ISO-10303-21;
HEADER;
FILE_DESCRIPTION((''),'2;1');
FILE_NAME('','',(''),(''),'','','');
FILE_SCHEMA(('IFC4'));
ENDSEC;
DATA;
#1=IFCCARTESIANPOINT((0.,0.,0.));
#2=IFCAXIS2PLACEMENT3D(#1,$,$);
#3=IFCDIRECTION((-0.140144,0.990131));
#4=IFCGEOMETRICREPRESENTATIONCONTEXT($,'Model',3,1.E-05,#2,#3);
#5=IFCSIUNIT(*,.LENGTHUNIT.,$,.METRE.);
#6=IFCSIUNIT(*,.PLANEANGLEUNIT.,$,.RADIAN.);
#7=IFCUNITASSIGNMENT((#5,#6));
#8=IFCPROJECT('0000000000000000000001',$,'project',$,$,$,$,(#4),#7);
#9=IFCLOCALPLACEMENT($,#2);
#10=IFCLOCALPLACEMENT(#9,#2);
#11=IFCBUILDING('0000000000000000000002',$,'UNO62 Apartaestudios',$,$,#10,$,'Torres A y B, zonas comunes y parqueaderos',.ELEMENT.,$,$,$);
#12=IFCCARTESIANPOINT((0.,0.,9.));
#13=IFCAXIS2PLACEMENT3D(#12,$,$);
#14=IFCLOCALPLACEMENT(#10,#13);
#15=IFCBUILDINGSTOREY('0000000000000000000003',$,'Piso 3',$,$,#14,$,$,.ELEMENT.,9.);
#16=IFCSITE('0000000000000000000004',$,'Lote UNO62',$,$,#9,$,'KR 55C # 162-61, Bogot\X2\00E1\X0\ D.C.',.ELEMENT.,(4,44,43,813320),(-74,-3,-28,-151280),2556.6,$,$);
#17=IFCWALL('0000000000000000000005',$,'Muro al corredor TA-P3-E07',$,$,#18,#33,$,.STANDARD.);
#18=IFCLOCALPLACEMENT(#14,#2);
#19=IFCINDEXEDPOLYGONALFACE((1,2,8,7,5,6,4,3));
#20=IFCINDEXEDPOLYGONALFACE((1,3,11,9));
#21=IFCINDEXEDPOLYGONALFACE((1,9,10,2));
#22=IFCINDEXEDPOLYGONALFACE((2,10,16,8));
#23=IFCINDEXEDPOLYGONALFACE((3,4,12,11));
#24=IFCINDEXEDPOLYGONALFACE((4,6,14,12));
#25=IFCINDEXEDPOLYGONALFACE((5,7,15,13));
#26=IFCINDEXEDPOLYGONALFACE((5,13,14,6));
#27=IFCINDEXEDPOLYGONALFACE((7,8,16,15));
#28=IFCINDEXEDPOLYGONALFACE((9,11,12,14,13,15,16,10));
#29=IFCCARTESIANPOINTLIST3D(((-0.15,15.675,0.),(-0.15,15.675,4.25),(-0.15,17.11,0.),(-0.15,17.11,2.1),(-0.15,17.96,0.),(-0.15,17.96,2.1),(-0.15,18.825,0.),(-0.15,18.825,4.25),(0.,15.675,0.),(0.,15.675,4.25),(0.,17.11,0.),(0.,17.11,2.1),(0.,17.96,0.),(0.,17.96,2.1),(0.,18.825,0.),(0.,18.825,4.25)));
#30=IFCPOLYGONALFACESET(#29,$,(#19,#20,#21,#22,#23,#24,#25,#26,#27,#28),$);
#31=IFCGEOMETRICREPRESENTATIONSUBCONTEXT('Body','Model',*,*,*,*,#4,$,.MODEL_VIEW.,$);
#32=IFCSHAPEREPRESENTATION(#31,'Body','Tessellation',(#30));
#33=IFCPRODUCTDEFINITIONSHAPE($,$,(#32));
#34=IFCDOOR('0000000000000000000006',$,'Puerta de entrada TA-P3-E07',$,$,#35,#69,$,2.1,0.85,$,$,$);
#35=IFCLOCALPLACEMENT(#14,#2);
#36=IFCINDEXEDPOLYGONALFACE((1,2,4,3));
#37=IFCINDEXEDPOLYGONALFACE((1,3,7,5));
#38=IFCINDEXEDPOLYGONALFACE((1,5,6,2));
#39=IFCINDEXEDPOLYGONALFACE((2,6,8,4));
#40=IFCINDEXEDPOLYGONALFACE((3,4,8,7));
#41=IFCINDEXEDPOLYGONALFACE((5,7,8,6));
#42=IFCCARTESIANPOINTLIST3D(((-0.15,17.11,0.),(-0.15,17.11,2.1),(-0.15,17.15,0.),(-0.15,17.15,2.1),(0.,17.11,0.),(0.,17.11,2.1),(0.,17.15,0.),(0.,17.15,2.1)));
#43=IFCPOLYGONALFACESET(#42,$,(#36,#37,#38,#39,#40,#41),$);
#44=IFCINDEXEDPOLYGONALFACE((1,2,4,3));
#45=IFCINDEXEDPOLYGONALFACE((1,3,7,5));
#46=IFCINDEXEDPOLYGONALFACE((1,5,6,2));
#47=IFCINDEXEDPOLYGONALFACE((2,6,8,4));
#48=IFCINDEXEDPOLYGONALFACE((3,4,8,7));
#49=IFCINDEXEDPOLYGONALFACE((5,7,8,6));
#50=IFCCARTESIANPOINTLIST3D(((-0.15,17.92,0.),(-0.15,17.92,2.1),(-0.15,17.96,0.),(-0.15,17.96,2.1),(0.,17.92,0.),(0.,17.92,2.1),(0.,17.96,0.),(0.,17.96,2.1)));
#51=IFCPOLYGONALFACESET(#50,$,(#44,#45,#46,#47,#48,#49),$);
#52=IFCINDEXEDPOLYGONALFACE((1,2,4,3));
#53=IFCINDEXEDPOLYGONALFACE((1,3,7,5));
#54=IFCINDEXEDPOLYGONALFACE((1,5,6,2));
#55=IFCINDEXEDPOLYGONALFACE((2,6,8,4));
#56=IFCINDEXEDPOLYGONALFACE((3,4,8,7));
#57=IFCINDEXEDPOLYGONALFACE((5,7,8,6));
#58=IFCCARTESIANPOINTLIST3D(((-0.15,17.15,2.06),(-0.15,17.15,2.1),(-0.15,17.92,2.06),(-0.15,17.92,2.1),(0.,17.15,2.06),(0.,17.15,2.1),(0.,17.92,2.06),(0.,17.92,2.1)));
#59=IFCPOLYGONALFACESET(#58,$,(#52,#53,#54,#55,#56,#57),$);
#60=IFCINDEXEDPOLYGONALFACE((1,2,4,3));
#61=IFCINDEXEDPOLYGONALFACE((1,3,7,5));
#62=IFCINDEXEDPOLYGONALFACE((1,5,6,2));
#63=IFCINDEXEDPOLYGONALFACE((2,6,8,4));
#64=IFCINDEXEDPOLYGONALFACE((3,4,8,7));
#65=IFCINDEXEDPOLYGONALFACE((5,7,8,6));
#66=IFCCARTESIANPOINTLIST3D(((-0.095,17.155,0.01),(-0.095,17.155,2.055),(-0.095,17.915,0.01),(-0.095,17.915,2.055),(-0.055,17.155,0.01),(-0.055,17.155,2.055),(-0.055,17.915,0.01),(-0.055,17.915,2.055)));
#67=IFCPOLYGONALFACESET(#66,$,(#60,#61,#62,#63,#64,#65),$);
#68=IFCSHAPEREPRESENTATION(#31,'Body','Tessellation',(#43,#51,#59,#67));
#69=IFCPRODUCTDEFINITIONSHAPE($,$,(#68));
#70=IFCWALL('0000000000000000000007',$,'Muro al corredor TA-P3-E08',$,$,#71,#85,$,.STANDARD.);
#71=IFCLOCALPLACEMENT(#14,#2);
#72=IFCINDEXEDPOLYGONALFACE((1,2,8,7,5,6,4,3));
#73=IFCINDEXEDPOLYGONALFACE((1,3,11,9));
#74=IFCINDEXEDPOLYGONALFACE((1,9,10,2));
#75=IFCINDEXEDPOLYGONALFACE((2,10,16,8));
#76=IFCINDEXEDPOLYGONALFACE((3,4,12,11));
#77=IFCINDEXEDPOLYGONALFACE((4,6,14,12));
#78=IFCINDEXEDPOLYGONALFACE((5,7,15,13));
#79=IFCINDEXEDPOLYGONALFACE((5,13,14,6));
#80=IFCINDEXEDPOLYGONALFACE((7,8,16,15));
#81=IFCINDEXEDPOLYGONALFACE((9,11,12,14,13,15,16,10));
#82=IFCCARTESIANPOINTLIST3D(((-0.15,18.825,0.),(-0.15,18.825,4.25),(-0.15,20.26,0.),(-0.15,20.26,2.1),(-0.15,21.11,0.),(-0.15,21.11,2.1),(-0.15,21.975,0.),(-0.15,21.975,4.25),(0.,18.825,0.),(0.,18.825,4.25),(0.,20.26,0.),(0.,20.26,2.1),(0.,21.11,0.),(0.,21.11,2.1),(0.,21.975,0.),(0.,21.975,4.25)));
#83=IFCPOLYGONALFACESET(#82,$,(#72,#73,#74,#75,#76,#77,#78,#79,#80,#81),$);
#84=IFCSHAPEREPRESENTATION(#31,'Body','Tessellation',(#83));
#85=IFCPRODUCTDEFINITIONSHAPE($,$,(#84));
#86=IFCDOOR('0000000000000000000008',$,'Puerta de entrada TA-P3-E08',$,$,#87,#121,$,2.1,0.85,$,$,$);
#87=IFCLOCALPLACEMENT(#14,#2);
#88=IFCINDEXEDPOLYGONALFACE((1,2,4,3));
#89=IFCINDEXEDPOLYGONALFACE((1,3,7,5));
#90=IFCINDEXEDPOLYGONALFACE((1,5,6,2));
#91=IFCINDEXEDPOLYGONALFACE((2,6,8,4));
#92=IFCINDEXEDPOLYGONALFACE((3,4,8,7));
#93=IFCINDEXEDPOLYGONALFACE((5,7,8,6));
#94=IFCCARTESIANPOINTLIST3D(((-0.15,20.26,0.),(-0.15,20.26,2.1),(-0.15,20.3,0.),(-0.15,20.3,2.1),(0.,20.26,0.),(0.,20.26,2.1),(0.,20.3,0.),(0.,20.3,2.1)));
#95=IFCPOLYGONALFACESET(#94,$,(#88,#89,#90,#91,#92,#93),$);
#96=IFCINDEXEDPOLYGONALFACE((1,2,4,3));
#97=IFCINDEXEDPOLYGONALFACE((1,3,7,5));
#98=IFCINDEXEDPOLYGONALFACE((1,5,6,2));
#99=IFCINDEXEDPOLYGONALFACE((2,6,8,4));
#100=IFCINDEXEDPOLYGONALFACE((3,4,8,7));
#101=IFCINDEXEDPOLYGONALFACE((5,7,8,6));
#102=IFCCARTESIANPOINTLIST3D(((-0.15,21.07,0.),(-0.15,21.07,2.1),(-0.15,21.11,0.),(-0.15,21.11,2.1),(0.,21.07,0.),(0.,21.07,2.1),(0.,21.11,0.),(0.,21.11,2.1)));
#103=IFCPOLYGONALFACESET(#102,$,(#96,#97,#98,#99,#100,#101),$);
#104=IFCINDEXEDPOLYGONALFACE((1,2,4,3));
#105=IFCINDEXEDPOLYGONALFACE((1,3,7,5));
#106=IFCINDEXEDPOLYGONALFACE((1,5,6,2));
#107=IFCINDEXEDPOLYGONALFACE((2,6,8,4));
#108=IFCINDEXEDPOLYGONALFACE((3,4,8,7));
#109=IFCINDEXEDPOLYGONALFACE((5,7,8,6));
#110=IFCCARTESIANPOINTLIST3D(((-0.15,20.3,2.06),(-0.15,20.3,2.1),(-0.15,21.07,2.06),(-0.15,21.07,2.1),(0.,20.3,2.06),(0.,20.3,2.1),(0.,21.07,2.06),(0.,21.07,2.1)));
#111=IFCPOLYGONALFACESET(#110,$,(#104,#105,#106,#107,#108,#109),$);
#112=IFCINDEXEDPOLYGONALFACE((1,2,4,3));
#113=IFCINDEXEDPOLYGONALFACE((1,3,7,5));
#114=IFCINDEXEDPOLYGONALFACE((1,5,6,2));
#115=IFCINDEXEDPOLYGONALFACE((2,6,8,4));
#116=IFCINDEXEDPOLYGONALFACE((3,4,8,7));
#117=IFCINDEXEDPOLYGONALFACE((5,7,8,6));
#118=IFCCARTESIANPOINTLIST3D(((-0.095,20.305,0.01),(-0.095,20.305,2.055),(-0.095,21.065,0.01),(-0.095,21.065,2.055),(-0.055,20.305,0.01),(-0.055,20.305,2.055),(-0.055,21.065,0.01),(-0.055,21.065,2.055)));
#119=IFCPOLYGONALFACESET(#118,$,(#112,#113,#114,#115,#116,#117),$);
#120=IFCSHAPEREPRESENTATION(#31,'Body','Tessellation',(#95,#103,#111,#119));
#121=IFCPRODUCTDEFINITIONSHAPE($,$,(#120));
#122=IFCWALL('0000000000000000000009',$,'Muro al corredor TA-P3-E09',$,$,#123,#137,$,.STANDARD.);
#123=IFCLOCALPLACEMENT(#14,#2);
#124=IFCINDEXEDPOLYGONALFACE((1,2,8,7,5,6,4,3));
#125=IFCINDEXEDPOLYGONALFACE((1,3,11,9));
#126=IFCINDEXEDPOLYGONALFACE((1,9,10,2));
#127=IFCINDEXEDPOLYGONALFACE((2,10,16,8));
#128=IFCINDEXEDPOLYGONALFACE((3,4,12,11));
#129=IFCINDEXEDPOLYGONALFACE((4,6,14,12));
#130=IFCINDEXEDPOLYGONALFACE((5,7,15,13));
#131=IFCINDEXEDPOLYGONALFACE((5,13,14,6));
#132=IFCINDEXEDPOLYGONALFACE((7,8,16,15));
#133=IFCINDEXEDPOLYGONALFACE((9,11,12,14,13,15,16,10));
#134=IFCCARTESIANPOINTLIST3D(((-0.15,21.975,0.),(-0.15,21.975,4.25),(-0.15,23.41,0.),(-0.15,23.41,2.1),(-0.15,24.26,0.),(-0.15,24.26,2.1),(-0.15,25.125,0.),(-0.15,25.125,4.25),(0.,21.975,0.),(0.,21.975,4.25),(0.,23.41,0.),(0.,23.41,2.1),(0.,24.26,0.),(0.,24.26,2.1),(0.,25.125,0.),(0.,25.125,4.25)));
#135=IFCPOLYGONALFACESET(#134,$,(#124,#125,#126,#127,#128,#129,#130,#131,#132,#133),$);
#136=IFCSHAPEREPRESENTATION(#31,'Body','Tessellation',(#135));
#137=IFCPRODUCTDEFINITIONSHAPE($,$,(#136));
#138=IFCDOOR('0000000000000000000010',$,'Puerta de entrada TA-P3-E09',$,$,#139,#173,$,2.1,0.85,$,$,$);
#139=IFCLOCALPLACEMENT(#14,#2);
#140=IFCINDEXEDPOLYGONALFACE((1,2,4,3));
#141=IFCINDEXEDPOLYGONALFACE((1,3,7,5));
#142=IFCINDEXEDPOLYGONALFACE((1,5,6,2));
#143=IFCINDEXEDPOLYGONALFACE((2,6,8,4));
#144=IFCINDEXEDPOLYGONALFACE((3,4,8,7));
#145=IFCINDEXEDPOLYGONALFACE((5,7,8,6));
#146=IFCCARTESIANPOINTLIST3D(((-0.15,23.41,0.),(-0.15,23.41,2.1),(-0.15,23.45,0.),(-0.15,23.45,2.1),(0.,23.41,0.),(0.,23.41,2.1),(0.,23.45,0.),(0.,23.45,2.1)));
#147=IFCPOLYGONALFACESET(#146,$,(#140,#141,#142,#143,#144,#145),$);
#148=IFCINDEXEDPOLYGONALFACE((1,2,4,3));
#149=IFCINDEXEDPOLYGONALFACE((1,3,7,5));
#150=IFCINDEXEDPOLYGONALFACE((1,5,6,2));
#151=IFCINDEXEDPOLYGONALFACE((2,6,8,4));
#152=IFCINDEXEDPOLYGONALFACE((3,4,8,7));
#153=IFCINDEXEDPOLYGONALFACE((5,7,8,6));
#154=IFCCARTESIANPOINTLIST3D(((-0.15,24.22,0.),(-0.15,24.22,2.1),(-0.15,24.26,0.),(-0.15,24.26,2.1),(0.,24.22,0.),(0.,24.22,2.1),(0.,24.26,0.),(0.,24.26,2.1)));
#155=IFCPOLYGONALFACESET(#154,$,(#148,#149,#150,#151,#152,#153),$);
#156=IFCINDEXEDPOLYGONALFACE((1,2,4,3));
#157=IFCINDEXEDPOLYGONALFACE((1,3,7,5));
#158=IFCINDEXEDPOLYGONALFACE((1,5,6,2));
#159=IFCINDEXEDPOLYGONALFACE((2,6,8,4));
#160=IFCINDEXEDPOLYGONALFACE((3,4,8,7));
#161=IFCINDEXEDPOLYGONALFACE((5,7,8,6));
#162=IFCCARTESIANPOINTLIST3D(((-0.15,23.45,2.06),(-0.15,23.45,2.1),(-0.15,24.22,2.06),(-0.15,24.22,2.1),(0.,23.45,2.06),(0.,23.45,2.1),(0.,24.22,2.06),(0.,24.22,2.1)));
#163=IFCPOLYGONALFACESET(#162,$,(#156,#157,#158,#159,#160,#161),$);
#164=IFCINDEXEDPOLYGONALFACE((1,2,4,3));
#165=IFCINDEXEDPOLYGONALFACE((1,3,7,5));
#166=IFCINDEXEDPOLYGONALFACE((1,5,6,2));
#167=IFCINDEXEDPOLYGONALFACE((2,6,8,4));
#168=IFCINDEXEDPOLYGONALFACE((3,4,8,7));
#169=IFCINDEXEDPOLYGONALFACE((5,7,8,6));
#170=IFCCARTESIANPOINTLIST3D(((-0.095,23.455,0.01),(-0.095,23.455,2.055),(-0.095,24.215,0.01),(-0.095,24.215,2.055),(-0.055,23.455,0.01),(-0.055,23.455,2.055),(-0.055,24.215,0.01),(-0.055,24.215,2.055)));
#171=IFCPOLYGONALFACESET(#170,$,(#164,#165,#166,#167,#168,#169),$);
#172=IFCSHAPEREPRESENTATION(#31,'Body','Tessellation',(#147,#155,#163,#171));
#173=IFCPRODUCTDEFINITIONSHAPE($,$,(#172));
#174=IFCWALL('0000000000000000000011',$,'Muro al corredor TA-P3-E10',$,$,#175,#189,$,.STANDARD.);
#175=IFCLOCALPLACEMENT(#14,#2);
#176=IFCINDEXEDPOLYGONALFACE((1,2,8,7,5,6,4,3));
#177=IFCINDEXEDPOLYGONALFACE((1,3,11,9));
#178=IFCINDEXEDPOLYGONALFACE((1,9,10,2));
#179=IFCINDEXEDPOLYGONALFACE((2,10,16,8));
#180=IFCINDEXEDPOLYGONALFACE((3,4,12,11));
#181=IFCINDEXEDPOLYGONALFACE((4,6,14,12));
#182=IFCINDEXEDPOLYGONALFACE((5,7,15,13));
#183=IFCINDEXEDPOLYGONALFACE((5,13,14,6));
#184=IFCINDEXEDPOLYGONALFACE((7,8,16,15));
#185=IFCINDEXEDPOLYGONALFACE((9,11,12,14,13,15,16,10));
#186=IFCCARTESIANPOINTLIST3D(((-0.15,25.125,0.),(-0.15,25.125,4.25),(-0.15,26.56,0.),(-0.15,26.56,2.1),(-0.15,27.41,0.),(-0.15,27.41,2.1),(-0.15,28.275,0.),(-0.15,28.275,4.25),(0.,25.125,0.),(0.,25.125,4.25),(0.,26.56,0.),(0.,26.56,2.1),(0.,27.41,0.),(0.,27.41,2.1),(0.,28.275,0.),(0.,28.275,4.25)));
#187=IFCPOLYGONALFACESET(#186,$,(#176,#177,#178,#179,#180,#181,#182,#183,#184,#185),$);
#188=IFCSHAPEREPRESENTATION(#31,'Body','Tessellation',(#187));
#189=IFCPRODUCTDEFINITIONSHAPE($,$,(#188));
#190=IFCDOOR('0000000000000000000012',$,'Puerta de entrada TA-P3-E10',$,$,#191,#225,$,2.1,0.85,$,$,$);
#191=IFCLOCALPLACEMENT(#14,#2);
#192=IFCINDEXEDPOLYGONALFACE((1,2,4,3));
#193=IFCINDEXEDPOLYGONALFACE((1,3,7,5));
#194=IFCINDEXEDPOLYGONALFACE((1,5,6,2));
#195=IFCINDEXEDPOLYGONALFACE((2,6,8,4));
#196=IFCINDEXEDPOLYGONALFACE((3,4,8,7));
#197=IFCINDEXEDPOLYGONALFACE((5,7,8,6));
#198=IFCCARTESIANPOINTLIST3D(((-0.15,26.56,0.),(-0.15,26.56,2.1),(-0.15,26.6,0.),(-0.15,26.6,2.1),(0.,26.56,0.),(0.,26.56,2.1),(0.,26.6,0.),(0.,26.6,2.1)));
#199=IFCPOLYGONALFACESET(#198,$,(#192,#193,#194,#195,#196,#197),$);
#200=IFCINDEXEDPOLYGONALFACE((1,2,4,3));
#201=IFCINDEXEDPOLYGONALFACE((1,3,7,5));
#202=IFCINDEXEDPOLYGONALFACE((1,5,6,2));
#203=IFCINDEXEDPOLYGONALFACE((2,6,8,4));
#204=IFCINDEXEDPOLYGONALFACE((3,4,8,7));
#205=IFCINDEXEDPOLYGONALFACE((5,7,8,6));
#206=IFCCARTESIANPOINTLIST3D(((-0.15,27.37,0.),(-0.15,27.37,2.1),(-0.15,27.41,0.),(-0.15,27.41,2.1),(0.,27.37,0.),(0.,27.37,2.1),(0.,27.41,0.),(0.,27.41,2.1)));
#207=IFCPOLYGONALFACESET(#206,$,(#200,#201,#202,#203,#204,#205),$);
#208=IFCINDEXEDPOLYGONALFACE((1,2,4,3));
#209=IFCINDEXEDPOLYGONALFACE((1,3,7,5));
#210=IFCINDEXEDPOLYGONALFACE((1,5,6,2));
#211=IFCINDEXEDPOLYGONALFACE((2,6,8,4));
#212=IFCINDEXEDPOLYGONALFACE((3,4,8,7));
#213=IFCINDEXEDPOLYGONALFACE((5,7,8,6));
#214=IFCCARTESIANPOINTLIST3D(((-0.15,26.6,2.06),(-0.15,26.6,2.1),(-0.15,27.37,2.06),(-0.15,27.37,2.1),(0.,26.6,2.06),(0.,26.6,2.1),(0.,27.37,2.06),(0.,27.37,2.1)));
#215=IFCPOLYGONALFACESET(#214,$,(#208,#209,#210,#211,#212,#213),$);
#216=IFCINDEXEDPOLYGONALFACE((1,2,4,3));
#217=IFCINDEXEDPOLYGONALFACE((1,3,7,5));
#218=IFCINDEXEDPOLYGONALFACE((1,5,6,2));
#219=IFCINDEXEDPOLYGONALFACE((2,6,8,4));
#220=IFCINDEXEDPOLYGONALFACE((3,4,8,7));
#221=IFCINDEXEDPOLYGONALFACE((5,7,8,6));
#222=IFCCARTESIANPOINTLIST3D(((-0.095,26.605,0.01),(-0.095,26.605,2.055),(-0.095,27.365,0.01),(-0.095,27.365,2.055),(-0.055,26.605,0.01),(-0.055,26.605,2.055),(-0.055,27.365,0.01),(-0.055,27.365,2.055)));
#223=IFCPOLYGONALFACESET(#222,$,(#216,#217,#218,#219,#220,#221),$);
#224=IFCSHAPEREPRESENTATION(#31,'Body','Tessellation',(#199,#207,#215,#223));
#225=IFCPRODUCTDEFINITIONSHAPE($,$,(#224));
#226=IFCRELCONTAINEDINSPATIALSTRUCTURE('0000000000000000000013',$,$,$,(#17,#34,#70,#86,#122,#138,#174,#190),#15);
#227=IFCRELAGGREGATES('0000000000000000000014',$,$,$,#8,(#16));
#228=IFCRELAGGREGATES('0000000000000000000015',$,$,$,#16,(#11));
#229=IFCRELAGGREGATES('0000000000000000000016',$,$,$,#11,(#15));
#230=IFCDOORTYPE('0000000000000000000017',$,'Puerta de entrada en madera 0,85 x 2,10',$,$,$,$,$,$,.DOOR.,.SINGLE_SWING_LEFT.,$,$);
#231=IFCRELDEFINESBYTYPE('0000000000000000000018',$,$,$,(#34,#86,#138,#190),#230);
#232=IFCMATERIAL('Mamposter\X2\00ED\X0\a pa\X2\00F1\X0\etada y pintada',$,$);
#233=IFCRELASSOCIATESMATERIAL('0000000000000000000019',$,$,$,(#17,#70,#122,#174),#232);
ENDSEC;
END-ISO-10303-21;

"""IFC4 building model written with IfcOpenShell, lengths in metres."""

from ifc_helpers import new_model, si_unit, direction, frame, frame_2d, origin, place, context, subcontext, project, spatial, rectangle, extrude, source, transform, mapped, material, type_object, type_shapes, element, fill, save


model = new_model("IFC4")

# Units and contexts
model_context = context("Model", 3, precision=1e-05, world=origin(), true_north=direction((-0.140144, 0.990131)))
body_context = subcontext(model_context, "Body", "Model", "MODEL_VIEW")
ifc_project = project(units=[si_unit("LENGTHUNIT", "METRE"), si_unit("PLANEANGLEUNIT", "RADIAN")], contexts=[model_context])

# Site, building, storey
site_placement = place(None, origin())
site = spatial("IfcSite", under=ifc_project, at=site_placement, Name="Lote UNO62", LongName="KR 55C # 162-61, Bogotá D.C.", CompositionType="ELEMENT", RefLatitude=(4, 44, 43, 813320), RefLongitude=(-74, -3, -28, -151280), RefElevation=2556.6)
building_placement = place(site_placement, origin())
building = spatial("IfcBuilding", under=site, at=building_placement, Name="UNO62 Apartaestudios", LongName="Torres A y B, zonas comunes y parqueaderos", CompositionType="ELEMENT")
storey_placement = place(building_placement, frame((0.0, 0.0, 9.0)))
storey = spatial("IfcBuildingStorey", under=building, at=storey_placement, Name="Piso 3", CompositionType="ELEMENT", Elevation=9.0)

# Walls, openings, doors
ifc_material = material(Name="Mampostería pañetada y pintada")
wall_1_placement = place(storey_placement, origin())
wall_1 = element("IfcWall", 1, at=wall_1_placement, inside=storey, material=ifc_material, Name="Muro al corredor TA-P3-E07", PredefinedType="STANDARD", context=body_context, shape_type="SweptSolid", body=[
    extrude(rectangle(XDim=0.15, YDim=3.15, at=frame_2d((-0.075, 17.25))), origin(), (0.0, 0.0, 1.0), 4.25),
])
opening_1_placement = place(wall_1_placement, origin())
opening_1 = element("IfcOpeningElement", 2, at=opening_1_placement, cuts=wall_1, PredefinedType="OPENING", context=body_context, shape_type="SweptSolid", body=[
    extrude(rectangle(XDim=0.25, YDim=0.85, at=frame_2d((-0.075, 17.535))), origin(), (0.0, 0.0, 1.0), 2.1),
])
door_type = type_object("IfcDoorType", Name="Puerta de entrada en madera 0,85 x 2,10", OperationType="SINGLE_SWING_LEFT", PredefinedType="DOOR")
shared_shape = source(origin(), body_context, "Body", "SweptSolid", [
    extrude(rectangle(XDim=0.15, YDim=0.04, at=frame_2d((-0.075, 1.38))), origin(), (0.0, 0.0, 1.0), 2.1),
    extrude(rectangle(XDim=0.15, YDim=0.04, at=frame_2d((-0.075, 2.19))), origin(), (0.0, 0.0, 1.0), 2.1),
    extrude(rectangle(XDim=0.15, YDim=0.77, at=frame_2d((-0.075, 1.785))), frame((0.0, 0.0, 2.06)), (0.0, 0.0, 1.0), 0.04),
    extrude(rectangle(XDim=0.04, YDim=0.76, at=frame_2d((-0.075, 1.785))), frame((0.0, 0.0, 0.01)), (0.0, 0.0, 1.0), 2.045),
])
type_shapes(door_type, [shared_shape])
placement_1 = place(storey_placement, frame((0.0, 15.75, 0.0)))
door_1_placement = place(placement_1, origin())
door_1 = element("IfcDoor", 3, at=door_1_placement, inside=storey, type_object=door_type, Name="Puerta de entrada TA-P3-E07", OverallHeight=2.1, OverallWidth=0.85, context=body_context, shape_type="MappedRepresentation", body=[
    mapped(shared_shape, transform((0.0, 0.0, 0.0))),
])
fill(opening_1, door_1)
wall_2_placement = place(storey_placement, origin())
wall_2 = element("IfcWall", 4, at=wall_2_placement, inside=storey, material=ifc_material, Name="Muro al corredor TA-P3-E08", PredefinedType="STANDARD", context=body_context, shape_type="SweptSolid", body=[
    extrude(rectangle(XDim=0.15, YDim=3.15, at=frame_2d((-0.075, 20.4))), origin(), (0.0, 0.0, 1.0), 4.25),
])
opening_2_placement = place(wall_2_placement, origin())
opening_2 = element("IfcOpeningElement", 5, at=opening_2_placement, cuts=wall_2, PredefinedType="OPENING", context=body_context, shape_type="SweptSolid", body=[
    extrude(rectangle(XDim=0.25, YDim=0.85, at=frame_2d((-0.075, 20.685))), origin(), (0.0, 0.0, 1.0), 2.1),
])
placement_2 = place(storey_placement, frame((0.0, 18.9, 0.0)))
door_2_placement = place(placement_2, origin())
door_2 = element("IfcDoor", 6, at=door_2_placement, inside=storey, type_object=door_type, Name="Puerta de entrada TA-P3-E08", OverallHeight=2.1, OverallWidth=0.85, context=body_context, shape_type="MappedRepresentation", body=[
    mapped(shared_shape, transform((0.0, 0.0, 0.0))),
])
fill(opening_2, door_2)
wall_3_placement = place(storey_placement, origin())
wall_3 = element("IfcWall", 7, at=wall_3_placement, inside=storey, material=ifc_material, Name="Muro al corredor TA-P3-E09", PredefinedType="STANDARD", context=body_context, shape_type="SweptSolid", body=[
    extrude(rectangle(XDim=0.15, YDim=3.15, at=frame_2d((-0.075, 23.55))), origin(), (0.0, 0.0, 1.0), 4.25),
])
opening_3_placement = place(wall_3_placement, origin())
opening_3 = element("IfcOpeningElement", 8, at=opening_3_placement, cuts=wall_3, PredefinedType="OPENING", context=body_context, shape_type="SweptSolid", body=[
    extrude(rectangle(XDim=0.25, YDim=0.85, at=frame_2d((-0.075, 23.835))), origin(), (0.0, 0.0, 1.0), 2.1),
])
placement_3 = place(storey_placement, frame((0.0, 22.05, 0.0)))
door_3_placement = place(placement_3, origin())
door_3 = element("IfcDoor", 9, at=door_3_placement, inside=storey, type_object=door_type, Name="Puerta de entrada TA-P3-E09", OverallHeight=2.1, OverallWidth=0.85, context=body_context, shape_type="MappedRepresentation", body=[
    mapped(shared_shape, transform((0.0, 0.0, 0.0))),
])
fill(opening_3, door_3)
wall_4_placement = place(storey_placement, origin())
wall_4 = element("IfcWall", 10, at=wall_4_placement, inside=storey, material=ifc_material, Name="Muro al corredor TA-P3-E10", PredefinedType="STANDARD", context=body_context, shape_type="SweptSolid", body=[
    extrude(rectangle(XDim=0.15, YDim=3.15, at=frame_2d((-0.075, 26.7))), origin(), (0.0, 0.0, 1.0), 4.25),
])
opening_4_placement = place(wall_4_placement, origin())
opening_4 = element("IfcOpeningElement", 11, at=opening_4_placement, cuts=wall_4, PredefinedType="OPENING", context=body_context, shape_type="SweptSolid", body=[
    extrude(rectangle(XDim=0.25, YDim=0.85, at=frame_2d((-0.075, 26.985))), origin(), (0.0, 0.0, 1.0), 2.1),
])
placement_4 = place(storey_placement, frame((0.0, 25.2, 0.0)))
door_4_placement = place(placement_4, origin())
door_4 = element("IfcDoor", 12, at=door_4_placement, inside=storey, type_object=door_type, Name="Puerta de entrada TA-P3-E10", OverallHeight=2.1, OverallWidth=0.85, context=body_context, shape_type="MappedRepresentation", body=[
    mapped(shared_shape, transform((0.0, 0.0, 0.0))),
])
fill(opening_4, door_4)

save(model, "model.ifc")
